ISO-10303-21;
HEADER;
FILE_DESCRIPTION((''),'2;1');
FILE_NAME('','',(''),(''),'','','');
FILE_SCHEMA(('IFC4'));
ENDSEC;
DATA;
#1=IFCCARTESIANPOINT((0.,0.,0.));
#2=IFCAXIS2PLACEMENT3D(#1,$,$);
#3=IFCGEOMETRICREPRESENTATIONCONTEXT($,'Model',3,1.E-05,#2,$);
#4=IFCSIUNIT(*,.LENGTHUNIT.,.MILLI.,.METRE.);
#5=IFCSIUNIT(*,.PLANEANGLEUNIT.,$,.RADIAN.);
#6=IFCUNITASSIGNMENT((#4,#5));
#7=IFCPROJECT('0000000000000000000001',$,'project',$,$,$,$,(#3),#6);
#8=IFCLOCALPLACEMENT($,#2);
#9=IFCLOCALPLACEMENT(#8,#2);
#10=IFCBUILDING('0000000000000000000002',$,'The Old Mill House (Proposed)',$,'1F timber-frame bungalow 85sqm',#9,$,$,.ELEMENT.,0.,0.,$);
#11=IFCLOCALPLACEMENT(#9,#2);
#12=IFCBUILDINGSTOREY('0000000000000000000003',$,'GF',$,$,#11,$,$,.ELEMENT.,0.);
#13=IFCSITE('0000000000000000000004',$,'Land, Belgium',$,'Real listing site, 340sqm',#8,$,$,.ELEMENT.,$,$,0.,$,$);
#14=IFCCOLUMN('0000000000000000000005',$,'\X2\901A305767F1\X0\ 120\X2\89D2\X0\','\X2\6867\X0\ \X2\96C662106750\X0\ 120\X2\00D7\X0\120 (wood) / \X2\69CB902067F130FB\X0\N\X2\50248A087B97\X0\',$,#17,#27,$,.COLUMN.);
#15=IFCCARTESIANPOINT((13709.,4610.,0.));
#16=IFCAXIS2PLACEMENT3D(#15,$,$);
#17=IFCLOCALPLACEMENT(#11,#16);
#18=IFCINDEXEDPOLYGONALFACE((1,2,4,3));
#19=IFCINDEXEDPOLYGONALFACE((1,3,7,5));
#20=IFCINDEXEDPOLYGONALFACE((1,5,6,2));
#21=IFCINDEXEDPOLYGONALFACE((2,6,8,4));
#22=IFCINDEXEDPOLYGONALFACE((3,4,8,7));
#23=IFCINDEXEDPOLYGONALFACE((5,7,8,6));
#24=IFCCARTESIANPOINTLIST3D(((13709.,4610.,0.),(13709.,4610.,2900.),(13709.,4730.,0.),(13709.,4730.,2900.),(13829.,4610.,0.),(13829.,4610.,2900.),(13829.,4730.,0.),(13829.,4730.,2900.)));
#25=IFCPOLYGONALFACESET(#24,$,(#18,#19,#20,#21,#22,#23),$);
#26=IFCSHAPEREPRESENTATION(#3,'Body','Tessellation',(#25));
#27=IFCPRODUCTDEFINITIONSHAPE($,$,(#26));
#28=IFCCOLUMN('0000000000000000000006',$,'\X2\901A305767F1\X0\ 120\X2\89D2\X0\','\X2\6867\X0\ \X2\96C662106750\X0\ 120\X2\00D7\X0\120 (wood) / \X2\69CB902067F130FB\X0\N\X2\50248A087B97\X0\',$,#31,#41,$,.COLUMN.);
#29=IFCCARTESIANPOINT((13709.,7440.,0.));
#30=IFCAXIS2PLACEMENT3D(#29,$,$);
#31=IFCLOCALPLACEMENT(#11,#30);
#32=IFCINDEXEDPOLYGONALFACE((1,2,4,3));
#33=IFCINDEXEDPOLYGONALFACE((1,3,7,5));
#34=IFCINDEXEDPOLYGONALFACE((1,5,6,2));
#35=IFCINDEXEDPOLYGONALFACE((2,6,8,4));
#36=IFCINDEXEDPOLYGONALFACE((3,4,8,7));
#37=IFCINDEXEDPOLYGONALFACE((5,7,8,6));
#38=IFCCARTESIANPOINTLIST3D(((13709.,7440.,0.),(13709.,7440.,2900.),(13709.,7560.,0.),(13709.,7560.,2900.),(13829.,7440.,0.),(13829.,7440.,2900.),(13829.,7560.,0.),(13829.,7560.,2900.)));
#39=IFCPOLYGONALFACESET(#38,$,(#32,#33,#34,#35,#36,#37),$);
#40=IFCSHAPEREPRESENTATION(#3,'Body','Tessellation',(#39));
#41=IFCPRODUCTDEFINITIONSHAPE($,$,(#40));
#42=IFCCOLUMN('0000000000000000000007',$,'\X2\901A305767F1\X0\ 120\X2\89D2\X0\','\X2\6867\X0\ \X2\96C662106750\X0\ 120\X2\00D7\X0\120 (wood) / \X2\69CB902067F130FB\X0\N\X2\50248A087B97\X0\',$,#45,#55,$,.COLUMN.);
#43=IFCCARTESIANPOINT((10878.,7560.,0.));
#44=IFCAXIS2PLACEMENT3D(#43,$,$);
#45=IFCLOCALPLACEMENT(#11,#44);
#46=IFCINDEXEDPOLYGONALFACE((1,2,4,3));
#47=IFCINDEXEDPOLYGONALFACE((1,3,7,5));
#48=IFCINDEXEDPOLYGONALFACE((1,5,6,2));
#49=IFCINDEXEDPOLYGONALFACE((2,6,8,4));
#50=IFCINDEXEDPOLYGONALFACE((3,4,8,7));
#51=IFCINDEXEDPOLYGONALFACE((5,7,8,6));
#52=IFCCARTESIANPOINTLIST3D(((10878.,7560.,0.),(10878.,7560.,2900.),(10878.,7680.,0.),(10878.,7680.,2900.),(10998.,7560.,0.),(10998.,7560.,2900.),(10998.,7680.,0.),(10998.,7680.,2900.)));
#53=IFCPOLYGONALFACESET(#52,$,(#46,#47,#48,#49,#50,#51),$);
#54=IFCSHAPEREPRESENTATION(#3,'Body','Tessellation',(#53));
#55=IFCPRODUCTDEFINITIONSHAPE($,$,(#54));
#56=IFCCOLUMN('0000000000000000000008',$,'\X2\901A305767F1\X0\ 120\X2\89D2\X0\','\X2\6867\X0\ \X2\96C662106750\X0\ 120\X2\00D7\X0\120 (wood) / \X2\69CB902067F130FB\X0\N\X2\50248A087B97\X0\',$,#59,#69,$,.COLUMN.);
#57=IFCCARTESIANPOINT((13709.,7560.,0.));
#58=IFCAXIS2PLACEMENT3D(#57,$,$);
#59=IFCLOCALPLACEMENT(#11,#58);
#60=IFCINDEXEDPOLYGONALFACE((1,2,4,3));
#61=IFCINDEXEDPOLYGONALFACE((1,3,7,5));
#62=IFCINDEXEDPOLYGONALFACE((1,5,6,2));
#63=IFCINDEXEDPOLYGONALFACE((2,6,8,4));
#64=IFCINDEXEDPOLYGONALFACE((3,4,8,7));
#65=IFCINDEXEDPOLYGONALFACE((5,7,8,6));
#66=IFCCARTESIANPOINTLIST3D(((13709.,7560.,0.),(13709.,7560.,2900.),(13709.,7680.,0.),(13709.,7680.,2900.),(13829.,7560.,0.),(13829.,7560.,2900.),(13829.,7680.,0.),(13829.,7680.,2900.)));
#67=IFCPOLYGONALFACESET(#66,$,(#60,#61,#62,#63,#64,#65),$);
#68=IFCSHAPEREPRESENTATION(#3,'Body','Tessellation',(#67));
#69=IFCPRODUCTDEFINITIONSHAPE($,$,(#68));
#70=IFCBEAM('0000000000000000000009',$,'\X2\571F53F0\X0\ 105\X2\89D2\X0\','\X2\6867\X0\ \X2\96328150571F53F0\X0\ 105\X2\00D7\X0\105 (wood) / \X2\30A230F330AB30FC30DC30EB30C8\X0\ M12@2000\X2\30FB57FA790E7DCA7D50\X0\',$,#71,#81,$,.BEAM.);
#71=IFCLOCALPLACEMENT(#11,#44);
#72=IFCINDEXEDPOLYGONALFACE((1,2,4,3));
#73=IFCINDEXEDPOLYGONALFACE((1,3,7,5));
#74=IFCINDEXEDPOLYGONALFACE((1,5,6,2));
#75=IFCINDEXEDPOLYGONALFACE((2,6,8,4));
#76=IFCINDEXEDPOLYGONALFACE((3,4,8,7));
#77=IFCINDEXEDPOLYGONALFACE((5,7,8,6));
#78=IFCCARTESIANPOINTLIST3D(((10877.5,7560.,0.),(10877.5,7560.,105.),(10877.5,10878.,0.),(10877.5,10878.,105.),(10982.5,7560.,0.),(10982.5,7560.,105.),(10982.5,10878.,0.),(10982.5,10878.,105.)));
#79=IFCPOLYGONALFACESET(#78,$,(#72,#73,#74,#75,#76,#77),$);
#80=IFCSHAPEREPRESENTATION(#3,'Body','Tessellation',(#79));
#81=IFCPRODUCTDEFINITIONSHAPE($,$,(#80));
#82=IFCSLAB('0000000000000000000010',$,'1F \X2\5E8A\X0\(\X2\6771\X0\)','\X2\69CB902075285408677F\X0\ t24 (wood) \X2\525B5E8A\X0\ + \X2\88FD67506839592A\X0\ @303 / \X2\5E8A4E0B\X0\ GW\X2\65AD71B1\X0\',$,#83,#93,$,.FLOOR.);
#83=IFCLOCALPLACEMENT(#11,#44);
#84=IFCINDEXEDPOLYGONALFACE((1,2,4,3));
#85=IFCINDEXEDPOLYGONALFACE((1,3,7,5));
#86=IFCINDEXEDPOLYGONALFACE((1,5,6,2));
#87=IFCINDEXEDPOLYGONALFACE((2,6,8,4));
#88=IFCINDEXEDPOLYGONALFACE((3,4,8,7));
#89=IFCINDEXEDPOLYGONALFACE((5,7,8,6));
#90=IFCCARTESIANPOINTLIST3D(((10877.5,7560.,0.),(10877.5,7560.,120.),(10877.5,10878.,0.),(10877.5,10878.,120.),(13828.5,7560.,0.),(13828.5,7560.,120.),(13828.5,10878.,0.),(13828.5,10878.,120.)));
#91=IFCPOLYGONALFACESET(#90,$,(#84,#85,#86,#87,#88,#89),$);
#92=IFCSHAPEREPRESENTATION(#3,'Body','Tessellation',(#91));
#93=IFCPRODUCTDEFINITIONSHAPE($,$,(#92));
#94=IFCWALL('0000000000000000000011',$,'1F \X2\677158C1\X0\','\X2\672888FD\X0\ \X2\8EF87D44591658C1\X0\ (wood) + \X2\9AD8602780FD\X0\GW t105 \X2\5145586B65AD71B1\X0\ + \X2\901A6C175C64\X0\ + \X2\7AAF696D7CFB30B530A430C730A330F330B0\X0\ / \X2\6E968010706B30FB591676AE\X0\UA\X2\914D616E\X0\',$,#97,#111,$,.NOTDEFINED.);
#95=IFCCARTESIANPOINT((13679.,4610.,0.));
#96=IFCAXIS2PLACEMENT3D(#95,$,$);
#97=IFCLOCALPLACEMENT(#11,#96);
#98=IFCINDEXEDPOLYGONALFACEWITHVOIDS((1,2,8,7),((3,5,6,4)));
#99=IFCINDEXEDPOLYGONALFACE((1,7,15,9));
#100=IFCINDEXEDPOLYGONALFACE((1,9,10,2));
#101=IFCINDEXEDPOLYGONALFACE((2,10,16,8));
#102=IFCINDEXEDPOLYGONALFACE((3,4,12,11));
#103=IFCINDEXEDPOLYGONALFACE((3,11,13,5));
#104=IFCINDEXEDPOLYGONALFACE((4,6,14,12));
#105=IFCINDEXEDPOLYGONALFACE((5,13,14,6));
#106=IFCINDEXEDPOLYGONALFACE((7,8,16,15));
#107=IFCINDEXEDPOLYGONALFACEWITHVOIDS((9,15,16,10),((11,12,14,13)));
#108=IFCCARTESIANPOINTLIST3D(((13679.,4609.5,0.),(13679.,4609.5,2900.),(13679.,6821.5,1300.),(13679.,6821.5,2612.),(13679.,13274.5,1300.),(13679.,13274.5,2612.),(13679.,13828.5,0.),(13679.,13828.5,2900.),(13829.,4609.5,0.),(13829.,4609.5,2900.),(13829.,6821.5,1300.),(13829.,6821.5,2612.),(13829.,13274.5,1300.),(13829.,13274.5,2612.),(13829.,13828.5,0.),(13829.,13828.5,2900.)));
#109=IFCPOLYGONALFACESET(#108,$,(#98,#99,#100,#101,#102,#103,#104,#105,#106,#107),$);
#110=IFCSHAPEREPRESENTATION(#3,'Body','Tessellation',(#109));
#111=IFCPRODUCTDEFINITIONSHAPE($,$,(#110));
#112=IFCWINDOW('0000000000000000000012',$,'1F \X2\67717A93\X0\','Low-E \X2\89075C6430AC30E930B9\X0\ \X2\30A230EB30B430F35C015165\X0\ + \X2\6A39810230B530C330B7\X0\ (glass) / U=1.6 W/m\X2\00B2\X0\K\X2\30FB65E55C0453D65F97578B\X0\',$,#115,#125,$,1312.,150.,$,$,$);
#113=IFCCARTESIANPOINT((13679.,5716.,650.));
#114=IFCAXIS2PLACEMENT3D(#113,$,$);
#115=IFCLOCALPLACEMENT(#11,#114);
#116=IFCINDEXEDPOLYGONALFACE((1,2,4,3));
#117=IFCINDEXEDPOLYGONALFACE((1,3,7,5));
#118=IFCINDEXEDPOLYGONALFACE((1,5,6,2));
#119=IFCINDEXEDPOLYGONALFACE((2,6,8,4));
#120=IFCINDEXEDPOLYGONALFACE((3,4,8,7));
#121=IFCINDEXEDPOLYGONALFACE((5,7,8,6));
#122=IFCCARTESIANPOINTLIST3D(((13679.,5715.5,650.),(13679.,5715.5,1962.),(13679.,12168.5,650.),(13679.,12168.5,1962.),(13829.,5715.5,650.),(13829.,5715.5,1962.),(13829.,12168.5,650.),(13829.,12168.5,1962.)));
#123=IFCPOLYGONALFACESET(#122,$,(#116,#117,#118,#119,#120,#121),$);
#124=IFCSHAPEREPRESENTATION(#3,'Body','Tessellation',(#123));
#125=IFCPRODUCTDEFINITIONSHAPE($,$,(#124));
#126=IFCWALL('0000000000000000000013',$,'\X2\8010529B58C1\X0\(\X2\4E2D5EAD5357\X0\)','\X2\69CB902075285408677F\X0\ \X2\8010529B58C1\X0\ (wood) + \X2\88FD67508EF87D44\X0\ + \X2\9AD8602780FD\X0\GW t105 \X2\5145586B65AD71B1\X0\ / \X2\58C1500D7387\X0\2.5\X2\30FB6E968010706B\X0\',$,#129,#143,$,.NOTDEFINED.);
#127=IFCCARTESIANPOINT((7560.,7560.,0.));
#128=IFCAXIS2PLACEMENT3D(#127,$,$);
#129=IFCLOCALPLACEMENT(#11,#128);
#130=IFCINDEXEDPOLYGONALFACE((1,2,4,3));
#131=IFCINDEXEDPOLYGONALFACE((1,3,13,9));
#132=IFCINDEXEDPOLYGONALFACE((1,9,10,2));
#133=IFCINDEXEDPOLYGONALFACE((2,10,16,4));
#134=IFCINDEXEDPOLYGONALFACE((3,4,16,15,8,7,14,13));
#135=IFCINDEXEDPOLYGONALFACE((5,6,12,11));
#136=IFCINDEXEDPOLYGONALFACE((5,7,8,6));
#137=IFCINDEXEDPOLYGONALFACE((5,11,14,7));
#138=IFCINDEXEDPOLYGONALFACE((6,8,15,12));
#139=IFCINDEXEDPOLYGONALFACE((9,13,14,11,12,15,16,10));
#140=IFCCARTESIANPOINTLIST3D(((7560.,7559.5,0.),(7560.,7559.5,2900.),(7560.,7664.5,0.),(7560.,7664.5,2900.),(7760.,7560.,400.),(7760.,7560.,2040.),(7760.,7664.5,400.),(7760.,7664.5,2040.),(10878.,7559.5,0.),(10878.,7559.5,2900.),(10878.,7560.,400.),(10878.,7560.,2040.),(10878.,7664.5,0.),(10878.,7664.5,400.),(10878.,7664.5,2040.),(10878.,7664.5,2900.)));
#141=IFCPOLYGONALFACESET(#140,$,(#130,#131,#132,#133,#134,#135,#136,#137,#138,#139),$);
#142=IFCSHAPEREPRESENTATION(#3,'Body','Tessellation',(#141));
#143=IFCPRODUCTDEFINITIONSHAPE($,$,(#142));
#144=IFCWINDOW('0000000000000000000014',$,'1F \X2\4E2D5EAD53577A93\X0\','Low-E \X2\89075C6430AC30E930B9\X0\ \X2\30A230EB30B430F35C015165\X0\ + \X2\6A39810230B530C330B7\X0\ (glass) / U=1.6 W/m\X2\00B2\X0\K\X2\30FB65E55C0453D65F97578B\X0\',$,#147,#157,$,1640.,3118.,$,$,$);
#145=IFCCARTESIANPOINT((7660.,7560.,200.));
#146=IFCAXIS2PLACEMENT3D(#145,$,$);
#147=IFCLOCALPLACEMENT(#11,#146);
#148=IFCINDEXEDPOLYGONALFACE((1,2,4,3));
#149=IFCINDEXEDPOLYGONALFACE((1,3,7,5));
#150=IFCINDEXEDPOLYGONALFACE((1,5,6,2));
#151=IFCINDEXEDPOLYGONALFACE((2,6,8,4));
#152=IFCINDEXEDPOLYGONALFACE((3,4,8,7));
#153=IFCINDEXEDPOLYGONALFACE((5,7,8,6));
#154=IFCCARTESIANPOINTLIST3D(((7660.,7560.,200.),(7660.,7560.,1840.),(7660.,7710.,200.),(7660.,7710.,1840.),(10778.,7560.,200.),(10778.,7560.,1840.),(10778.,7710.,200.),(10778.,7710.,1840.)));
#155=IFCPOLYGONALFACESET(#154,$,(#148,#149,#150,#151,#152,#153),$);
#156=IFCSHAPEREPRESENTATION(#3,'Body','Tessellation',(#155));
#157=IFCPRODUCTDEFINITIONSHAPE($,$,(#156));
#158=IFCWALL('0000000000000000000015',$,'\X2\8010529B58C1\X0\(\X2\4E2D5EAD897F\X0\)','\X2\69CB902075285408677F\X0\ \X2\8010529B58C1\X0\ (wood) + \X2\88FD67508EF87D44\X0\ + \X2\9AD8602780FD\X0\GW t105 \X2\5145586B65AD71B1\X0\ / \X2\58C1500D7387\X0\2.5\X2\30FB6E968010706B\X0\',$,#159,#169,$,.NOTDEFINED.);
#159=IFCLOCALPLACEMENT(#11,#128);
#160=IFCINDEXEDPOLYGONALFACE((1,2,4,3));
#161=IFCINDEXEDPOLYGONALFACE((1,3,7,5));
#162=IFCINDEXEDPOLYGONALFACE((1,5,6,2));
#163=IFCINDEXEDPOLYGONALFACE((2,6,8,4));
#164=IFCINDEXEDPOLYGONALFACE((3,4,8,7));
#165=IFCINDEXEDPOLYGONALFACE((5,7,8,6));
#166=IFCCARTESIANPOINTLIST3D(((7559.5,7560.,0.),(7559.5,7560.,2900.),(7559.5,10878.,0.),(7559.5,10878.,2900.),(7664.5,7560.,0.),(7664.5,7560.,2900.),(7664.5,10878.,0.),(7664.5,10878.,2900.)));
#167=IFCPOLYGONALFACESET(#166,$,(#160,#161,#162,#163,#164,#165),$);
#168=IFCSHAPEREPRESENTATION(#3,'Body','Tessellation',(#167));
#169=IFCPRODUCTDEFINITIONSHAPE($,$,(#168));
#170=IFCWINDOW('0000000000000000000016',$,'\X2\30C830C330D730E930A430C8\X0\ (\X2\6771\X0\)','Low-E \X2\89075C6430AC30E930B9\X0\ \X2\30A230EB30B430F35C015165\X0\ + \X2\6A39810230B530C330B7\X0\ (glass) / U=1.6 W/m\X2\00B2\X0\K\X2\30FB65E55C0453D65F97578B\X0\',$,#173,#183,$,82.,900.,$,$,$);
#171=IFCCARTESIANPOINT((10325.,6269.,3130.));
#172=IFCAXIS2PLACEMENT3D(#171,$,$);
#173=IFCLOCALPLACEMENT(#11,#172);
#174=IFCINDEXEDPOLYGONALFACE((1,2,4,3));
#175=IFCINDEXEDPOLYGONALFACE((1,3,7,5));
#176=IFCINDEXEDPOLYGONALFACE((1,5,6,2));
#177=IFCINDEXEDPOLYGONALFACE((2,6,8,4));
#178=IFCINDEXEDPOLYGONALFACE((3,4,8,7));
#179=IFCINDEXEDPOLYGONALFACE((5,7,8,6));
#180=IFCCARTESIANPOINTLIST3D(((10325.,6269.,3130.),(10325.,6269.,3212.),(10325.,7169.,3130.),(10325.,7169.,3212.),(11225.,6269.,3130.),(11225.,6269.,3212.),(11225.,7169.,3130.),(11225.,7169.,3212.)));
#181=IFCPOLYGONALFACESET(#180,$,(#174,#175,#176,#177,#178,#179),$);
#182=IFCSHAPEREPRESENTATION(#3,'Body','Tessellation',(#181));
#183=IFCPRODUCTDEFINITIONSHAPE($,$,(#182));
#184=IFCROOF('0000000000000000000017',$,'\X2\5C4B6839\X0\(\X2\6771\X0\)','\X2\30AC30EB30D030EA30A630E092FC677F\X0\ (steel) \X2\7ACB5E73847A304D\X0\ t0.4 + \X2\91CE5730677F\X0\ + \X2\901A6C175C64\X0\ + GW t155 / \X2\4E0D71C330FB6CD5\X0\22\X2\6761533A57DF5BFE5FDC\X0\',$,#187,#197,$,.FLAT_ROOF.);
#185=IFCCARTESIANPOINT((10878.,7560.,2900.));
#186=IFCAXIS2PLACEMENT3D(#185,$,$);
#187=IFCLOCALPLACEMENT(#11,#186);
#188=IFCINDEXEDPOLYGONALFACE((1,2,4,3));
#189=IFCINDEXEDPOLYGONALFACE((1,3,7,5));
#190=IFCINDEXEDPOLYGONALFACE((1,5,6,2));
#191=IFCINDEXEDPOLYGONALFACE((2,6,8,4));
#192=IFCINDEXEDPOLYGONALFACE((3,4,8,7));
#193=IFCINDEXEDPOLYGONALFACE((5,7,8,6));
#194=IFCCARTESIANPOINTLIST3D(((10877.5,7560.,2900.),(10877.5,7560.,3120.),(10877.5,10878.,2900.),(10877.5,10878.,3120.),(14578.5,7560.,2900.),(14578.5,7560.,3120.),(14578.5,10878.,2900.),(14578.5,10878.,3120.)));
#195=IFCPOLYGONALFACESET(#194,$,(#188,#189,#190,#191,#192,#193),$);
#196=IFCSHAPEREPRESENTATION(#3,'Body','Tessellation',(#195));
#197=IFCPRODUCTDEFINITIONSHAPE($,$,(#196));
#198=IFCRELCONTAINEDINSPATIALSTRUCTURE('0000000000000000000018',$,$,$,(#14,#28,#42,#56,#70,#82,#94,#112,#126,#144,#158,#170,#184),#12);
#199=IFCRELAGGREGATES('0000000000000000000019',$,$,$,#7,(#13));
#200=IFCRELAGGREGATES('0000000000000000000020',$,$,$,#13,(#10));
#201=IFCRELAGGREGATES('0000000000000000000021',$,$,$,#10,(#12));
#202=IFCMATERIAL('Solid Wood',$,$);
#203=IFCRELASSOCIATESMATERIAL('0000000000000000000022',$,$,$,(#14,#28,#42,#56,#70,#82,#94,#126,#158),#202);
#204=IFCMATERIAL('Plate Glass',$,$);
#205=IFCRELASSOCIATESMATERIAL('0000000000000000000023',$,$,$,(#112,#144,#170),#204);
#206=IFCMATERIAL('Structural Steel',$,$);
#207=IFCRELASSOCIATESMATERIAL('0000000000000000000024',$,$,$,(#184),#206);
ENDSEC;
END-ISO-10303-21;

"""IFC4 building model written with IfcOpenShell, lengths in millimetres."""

from ifc_helpers import new_model, si_unit, frame, frame_2d, origin, place, context, project, spatial, rectangle, extrude, material, element, fill, save


model = new_model("IFC4")

# Units and contexts
model_context = context("Model", 3, precision=1e-05, world=origin())
ifc_project = project(units=[si_unit("LENGTHUNIT", "METRE", prefix="MILLI"), si_unit("PLANEANGLEUNIT", "RADIAN")], contexts=[model_context])

# Site, building, storey
site_placement = place(None, origin())
site = spatial("IfcSite", under=ifc_project, at=site_placement, Name="Land, Belgium", ObjectType="Real listing site, 340sqm", CompositionType="ELEMENT", RefElevation=0.0)
building_placement = place(site_placement, origin())
building = spatial("IfcBuilding", under=site, at=building_placement, Name="The Old Mill House (Proposed)", ObjectType="1F timber-frame bungalow 85sqm", CompositionType="ELEMENT", ElevationOfRefHeight=0.0, ElevationOfTerrain=0.0)
storey_placement = place(building_placement, origin())
storey = spatial("IfcBuildingStorey", under=building, at=storey_placement, Name="GF", CompositionType="ELEMENT", Elevation=0.0)

# Columns
ifc_material_1 = material(Name="Solid Wood")
column_1_placement = place(storey_placement, frame((13709.0, 4610.0, 0.0)))
element("IfcColumn", 1, at=column_1_placement, inside=storey, material=ifc_material_1, Name="通し柱 120角", Description="桧 集成材 120×120 (wood) / 構造柱・N値計算", PredefinedType="COLUMN", context=model_context, shape_type="SweptSolid", body=[
    extrude(rectangle(XDim=120.0, YDim=120.0, at=frame_2d((60.0, 60.0))), frame((13709.0, 4610.0, 0.0)), (0.0, 0.0, 1.0), 2900.0),
])
column_2_placement = place(storey_placement, frame((13709.0, 7440.0, 0.0)))
element("IfcColumn", 2, at=column_2_placement, inside=storey, material=ifc_material_1, Name="通し柱 120角", Description="桧 集成材 120×120 (wood) / 構造柱・N値計算", PredefinedType="COLUMN", context=model_context, shape_type="SweptSolid", body=[
    extrude(rectangle(XDim=120.0, YDim=120.0, at=frame_2d((60.0, 60.0))), frame((13709.0, 7440.0, 0.0)), (0.0, 0.0, 1.0), 2900.0),
])
column_3_placement = place(storey_placement, frame((10878.0, 7560.0, 0.0)))
element("IfcColumn", 3, at=column_3_placement, inside=storey, material=ifc_material_1, Name="通し柱 120角", Description="桧 集成材 120×120 (wood) / 構造柱・N値計算", PredefinedType="COLUMN", context=model_context, shape_type="SweptSolid", body=[
    extrude(rectangle(XDim=120.0, YDim=120.0, at=frame_2d((60.0, 60.0))), frame((10878.0, 7560.0, 0.0)), (0.0, 0.0, 1.0), 2900.0),
])
column_4_placement = place(storey_placement, frame((13709.0, 7560.0, 0.0)))
element("IfcColumn", 4, at=column_4_placement, inside=storey, material=ifc_material_1, Name="通し柱 120角", Description="桧 集成材 120×120 (wood) / 構造柱・N値計算", PredefinedType="COLUMN", context=model_context, shape_type="SweptSolid", body=[
    extrude(rectangle(XDim=120.0, YDim=120.0, at=frame_2d((60.0, 60.0))), frame((13709.0, 7560.0, 0.0)), (0.0, 0.0, 1.0), 2900.0),
])

# Beam
beam_1_placement = place(storey_placement, frame((10878.0, 7560.0, 0.0)))
element("IfcBeam", 5, at=beam_1_placement, inside=storey, material=ifc_material_1, Name="土台 105角", Description="桧 防腐土台 105×105 (wood) / アンカーボルト M12@2000・基礎緊結", PredefinedType="BEAM", context=model_context, shape_type="SweptSolid", body=[
    extrude(rectangle(XDim=105.0, YDim=3318.0, at=frame_2d((52.0, 1659.0))), frame((10878.0, 7560.0, 0.0)), (0.0, 0.0, 1.0), 105.0),
])

# Slab
slab_placement = place(storey_placement, frame((10878.0, 7560.0, 0.0)))
element("IfcSlab", 6, at=slab_placement, inside=storey, material=ifc_material_1, Name="1F 床(東)", Description="構造用合板 t24 (wood) 剛床 + 製材根太 @303 / 床下 GW断熱", PredefinedType="FLOOR", context=model_context, shape_type="SweptSolid", body=[
    extrude(rectangle(XDim=2951.0, YDim=3318.0, at=frame_2d((1475.0, 1659.0))), frame((10878.0, 7560.0, 0.0)), (0.0, 0.0, 1.0), 120.0),
])

# Walls, openings, windows
wall_1_placement = place(storey_placement, frame((13679.0, 4610.0, 0.0)))
wall_1 = element("IfcWall", 7, at=wall_1_placement, inside=storey, material=ifc_material_1, Name="1F 東壁", Description="木製 軸組外壁 (wood) + 高性能GW t105 充填断熱 + 通気層 + 窯業系サイディング / 準耐火・外皮UA配慮", PredefinedType="NOTDEFINED", context=model_context, shape_type="SweptSolid", body=[
    extrude(rectangle(XDim=150.0, YDim=9219.0, at=frame_2d((75.0, 4609.0))), frame((13679.0, 4610.0, 0.0)), (0.0, 0.0, 1.0), 2900.0),
])
opening_1_placement = place(storey_placement, frame((13679.0, 5716.0, 650.0)))
opening_1 = element("IfcOpeningElement", 8, at=opening_1_placement, cuts=wall_1, PredefinedType="NOTDEFINED", context=model_context, shape_type="SweptSolid", body=[
    extrude(rectangle(XDim=150.0, YDim=6453.0, at=frame_2d((75.0, 3226.0))), frame((13679.0, 5716.0, 650.0)), (0.0, 0.0, 1.0), 1312.0),
])
ifc_material_2 = material(Name="Plate Glass")
window_1_placement = place(storey_placement, frame((13679.0, 5716.0, 650.0)))
window_1 = element("IfcWindow", 9, at=window_1_placement, inside=storey, material=ifc_material_2, Name="1F 東窓", Description="Low-E 複層ガラス アルゴン封入 + 樹脂サッシ (glass) / U=1.6 W/m²K・日射取得型", OverallHeight=1312.0, OverallWidth=150.0, context=model_context, shape_type="SweptSolid", body=[
    extrude(rectangle(XDim=150.0, YDim=6453.0, at=frame_2d((75.0, 3226.0))), frame((13679.0, 5716.0, 650.0)), (0.0, 0.0, 1.0), 1312.0),
])
fill(opening_1, window_1)
wall_2_placement = place(storey_placement, frame((7560.0, 7560.0, 0.0)))
wall_2 = element("IfcWall", 10, at=wall_2_placement, inside=storey, material=ifc_material_1, Name="耐力壁(中庭南)", Description="構造用合板 耐力壁 (wood) + 製材軸組 + 高性能GW t105 充填断熱 / 壁倍率2.5・準耐火", PredefinedType="NOTDEFINED", context=model_context, shape_type="SweptSolid", body=[
    extrude(rectangle(XDim=3318.0, YDim=105.0, at=frame_2d((1659.0, 52.0))), frame((7560.0, 7560.0, 0.0)), (0.0, 0.0, 1.0), 2900.0),
])
opening_2_placement = place(storey_placement, frame((7660.0, 7560.0, 200.0)))
opening_2 = element("IfcOpeningElement", 11, at=opening_2_placement, cuts=wall_2, PredefinedType="NOTDEFINED", context=model_context, shape_type="SweptSolid", body=[
    extrude(rectangle(XDim=3118.0, YDim=150.0, at=frame_2d((1559.0, 75.0))), frame((7660.0, 7560.0, 200.0)), (0.0, 0.0, 1.0), 1640.0),
])
window_2_placement = place(storey_placement, frame((7660.0, 7560.0, 200.0)))
window_2 = element("IfcWindow", 12, at=window_2_placement, inside=storey, material=ifc_material_2, Name="1F 中庭南窓", Description="Low-E 複層ガラス アルゴン封入 + 樹脂サッシ (glass) / U=1.6 W/m²K・日射取得型", OverallHeight=1640.0, OverallWidth=3118.0, context=model_context, shape_type="SweptSolid", body=[
    extrude(rectangle(XDim=3118.0, YDim=150.0, at=frame_2d((1559.0, 75.0))), frame((7660.0, 7560.0, 200.0)), (0.0, 0.0, 1.0), 1640.0),
])
fill(opening_2, window_2)

# Wall
wall_3_placement = place(storey_placement, frame((7560.0, 7560.0, 0.0)))
element("IfcWall", 13, at=wall_3_placement, inside=storey, material=ifc_material_1, Name="耐力壁(中庭西)", Description="構造用合板 耐力壁 (wood) + 製材軸組 + 高性能GW t105 充填断熱 / 壁倍率2.5・準耐火", PredefinedType="NOTDEFINED", context=model_context, shape_type="SweptSolid", body=[
    extrude(rectangle(XDim=105.0, YDim=3318.0, at=frame_2d((52.0, 1659.0))), frame((7560.0, 7560.0, 0.0)), (0.0, 0.0, 1.0), 2900.0),
])

# Window
window_3_placement = place(storey_placement, frame((10325.0, 6269.0, 3130.0)))
element("IfcWindow", 14, at=window_3_placement, inside=storey, material=ifc_material_2, Name="トップライト (東)", Description="Low-E 複層ガラス アルゴン封入 + 樹脂サッシ (glass) / U=1.6 W/m²K・日射取得型", OverallHeight=82.0, OverallWidth=900.0, context=model_context, shape_type="SweptSolid", body=[
    extrude(rectangle(XDim=900.0, YDim=900.0, at=frame_2d((450.0, 450.0))), frame((10325.0, 6269.0, 3130.0)), (0.0, 0.0, 1.0), 82.0),
])

# Roof
ifc_material_3 = material(Name="Structural Steel")
roof_placement = place(storey_placement, frame((10878.0, 7560.0, 2900.0)))
element("IfcRoof", 15, at=roof_placement, inside=storey, material=ifc_material_3, Name="屋根(東)", Description="ガルバリウム鋼板 (steel) 立平葺き t0.4 + 野地板 + 通気層 + GW t155 / 不燃・法22条区域対応", PredefinedType="FLAT_ROOF", context=model_context, shape_type="SweptSolid", body=[
    extrude(rectangle(XDim=3701.0, YDim=3318.0, at=frame_2d((1850.0, 1659.0))), frame((10878.0, 7560.0, 2900.0)), (0.0, 0.0, 1.0), 220.0),
])

save(model, "model.ifc")
